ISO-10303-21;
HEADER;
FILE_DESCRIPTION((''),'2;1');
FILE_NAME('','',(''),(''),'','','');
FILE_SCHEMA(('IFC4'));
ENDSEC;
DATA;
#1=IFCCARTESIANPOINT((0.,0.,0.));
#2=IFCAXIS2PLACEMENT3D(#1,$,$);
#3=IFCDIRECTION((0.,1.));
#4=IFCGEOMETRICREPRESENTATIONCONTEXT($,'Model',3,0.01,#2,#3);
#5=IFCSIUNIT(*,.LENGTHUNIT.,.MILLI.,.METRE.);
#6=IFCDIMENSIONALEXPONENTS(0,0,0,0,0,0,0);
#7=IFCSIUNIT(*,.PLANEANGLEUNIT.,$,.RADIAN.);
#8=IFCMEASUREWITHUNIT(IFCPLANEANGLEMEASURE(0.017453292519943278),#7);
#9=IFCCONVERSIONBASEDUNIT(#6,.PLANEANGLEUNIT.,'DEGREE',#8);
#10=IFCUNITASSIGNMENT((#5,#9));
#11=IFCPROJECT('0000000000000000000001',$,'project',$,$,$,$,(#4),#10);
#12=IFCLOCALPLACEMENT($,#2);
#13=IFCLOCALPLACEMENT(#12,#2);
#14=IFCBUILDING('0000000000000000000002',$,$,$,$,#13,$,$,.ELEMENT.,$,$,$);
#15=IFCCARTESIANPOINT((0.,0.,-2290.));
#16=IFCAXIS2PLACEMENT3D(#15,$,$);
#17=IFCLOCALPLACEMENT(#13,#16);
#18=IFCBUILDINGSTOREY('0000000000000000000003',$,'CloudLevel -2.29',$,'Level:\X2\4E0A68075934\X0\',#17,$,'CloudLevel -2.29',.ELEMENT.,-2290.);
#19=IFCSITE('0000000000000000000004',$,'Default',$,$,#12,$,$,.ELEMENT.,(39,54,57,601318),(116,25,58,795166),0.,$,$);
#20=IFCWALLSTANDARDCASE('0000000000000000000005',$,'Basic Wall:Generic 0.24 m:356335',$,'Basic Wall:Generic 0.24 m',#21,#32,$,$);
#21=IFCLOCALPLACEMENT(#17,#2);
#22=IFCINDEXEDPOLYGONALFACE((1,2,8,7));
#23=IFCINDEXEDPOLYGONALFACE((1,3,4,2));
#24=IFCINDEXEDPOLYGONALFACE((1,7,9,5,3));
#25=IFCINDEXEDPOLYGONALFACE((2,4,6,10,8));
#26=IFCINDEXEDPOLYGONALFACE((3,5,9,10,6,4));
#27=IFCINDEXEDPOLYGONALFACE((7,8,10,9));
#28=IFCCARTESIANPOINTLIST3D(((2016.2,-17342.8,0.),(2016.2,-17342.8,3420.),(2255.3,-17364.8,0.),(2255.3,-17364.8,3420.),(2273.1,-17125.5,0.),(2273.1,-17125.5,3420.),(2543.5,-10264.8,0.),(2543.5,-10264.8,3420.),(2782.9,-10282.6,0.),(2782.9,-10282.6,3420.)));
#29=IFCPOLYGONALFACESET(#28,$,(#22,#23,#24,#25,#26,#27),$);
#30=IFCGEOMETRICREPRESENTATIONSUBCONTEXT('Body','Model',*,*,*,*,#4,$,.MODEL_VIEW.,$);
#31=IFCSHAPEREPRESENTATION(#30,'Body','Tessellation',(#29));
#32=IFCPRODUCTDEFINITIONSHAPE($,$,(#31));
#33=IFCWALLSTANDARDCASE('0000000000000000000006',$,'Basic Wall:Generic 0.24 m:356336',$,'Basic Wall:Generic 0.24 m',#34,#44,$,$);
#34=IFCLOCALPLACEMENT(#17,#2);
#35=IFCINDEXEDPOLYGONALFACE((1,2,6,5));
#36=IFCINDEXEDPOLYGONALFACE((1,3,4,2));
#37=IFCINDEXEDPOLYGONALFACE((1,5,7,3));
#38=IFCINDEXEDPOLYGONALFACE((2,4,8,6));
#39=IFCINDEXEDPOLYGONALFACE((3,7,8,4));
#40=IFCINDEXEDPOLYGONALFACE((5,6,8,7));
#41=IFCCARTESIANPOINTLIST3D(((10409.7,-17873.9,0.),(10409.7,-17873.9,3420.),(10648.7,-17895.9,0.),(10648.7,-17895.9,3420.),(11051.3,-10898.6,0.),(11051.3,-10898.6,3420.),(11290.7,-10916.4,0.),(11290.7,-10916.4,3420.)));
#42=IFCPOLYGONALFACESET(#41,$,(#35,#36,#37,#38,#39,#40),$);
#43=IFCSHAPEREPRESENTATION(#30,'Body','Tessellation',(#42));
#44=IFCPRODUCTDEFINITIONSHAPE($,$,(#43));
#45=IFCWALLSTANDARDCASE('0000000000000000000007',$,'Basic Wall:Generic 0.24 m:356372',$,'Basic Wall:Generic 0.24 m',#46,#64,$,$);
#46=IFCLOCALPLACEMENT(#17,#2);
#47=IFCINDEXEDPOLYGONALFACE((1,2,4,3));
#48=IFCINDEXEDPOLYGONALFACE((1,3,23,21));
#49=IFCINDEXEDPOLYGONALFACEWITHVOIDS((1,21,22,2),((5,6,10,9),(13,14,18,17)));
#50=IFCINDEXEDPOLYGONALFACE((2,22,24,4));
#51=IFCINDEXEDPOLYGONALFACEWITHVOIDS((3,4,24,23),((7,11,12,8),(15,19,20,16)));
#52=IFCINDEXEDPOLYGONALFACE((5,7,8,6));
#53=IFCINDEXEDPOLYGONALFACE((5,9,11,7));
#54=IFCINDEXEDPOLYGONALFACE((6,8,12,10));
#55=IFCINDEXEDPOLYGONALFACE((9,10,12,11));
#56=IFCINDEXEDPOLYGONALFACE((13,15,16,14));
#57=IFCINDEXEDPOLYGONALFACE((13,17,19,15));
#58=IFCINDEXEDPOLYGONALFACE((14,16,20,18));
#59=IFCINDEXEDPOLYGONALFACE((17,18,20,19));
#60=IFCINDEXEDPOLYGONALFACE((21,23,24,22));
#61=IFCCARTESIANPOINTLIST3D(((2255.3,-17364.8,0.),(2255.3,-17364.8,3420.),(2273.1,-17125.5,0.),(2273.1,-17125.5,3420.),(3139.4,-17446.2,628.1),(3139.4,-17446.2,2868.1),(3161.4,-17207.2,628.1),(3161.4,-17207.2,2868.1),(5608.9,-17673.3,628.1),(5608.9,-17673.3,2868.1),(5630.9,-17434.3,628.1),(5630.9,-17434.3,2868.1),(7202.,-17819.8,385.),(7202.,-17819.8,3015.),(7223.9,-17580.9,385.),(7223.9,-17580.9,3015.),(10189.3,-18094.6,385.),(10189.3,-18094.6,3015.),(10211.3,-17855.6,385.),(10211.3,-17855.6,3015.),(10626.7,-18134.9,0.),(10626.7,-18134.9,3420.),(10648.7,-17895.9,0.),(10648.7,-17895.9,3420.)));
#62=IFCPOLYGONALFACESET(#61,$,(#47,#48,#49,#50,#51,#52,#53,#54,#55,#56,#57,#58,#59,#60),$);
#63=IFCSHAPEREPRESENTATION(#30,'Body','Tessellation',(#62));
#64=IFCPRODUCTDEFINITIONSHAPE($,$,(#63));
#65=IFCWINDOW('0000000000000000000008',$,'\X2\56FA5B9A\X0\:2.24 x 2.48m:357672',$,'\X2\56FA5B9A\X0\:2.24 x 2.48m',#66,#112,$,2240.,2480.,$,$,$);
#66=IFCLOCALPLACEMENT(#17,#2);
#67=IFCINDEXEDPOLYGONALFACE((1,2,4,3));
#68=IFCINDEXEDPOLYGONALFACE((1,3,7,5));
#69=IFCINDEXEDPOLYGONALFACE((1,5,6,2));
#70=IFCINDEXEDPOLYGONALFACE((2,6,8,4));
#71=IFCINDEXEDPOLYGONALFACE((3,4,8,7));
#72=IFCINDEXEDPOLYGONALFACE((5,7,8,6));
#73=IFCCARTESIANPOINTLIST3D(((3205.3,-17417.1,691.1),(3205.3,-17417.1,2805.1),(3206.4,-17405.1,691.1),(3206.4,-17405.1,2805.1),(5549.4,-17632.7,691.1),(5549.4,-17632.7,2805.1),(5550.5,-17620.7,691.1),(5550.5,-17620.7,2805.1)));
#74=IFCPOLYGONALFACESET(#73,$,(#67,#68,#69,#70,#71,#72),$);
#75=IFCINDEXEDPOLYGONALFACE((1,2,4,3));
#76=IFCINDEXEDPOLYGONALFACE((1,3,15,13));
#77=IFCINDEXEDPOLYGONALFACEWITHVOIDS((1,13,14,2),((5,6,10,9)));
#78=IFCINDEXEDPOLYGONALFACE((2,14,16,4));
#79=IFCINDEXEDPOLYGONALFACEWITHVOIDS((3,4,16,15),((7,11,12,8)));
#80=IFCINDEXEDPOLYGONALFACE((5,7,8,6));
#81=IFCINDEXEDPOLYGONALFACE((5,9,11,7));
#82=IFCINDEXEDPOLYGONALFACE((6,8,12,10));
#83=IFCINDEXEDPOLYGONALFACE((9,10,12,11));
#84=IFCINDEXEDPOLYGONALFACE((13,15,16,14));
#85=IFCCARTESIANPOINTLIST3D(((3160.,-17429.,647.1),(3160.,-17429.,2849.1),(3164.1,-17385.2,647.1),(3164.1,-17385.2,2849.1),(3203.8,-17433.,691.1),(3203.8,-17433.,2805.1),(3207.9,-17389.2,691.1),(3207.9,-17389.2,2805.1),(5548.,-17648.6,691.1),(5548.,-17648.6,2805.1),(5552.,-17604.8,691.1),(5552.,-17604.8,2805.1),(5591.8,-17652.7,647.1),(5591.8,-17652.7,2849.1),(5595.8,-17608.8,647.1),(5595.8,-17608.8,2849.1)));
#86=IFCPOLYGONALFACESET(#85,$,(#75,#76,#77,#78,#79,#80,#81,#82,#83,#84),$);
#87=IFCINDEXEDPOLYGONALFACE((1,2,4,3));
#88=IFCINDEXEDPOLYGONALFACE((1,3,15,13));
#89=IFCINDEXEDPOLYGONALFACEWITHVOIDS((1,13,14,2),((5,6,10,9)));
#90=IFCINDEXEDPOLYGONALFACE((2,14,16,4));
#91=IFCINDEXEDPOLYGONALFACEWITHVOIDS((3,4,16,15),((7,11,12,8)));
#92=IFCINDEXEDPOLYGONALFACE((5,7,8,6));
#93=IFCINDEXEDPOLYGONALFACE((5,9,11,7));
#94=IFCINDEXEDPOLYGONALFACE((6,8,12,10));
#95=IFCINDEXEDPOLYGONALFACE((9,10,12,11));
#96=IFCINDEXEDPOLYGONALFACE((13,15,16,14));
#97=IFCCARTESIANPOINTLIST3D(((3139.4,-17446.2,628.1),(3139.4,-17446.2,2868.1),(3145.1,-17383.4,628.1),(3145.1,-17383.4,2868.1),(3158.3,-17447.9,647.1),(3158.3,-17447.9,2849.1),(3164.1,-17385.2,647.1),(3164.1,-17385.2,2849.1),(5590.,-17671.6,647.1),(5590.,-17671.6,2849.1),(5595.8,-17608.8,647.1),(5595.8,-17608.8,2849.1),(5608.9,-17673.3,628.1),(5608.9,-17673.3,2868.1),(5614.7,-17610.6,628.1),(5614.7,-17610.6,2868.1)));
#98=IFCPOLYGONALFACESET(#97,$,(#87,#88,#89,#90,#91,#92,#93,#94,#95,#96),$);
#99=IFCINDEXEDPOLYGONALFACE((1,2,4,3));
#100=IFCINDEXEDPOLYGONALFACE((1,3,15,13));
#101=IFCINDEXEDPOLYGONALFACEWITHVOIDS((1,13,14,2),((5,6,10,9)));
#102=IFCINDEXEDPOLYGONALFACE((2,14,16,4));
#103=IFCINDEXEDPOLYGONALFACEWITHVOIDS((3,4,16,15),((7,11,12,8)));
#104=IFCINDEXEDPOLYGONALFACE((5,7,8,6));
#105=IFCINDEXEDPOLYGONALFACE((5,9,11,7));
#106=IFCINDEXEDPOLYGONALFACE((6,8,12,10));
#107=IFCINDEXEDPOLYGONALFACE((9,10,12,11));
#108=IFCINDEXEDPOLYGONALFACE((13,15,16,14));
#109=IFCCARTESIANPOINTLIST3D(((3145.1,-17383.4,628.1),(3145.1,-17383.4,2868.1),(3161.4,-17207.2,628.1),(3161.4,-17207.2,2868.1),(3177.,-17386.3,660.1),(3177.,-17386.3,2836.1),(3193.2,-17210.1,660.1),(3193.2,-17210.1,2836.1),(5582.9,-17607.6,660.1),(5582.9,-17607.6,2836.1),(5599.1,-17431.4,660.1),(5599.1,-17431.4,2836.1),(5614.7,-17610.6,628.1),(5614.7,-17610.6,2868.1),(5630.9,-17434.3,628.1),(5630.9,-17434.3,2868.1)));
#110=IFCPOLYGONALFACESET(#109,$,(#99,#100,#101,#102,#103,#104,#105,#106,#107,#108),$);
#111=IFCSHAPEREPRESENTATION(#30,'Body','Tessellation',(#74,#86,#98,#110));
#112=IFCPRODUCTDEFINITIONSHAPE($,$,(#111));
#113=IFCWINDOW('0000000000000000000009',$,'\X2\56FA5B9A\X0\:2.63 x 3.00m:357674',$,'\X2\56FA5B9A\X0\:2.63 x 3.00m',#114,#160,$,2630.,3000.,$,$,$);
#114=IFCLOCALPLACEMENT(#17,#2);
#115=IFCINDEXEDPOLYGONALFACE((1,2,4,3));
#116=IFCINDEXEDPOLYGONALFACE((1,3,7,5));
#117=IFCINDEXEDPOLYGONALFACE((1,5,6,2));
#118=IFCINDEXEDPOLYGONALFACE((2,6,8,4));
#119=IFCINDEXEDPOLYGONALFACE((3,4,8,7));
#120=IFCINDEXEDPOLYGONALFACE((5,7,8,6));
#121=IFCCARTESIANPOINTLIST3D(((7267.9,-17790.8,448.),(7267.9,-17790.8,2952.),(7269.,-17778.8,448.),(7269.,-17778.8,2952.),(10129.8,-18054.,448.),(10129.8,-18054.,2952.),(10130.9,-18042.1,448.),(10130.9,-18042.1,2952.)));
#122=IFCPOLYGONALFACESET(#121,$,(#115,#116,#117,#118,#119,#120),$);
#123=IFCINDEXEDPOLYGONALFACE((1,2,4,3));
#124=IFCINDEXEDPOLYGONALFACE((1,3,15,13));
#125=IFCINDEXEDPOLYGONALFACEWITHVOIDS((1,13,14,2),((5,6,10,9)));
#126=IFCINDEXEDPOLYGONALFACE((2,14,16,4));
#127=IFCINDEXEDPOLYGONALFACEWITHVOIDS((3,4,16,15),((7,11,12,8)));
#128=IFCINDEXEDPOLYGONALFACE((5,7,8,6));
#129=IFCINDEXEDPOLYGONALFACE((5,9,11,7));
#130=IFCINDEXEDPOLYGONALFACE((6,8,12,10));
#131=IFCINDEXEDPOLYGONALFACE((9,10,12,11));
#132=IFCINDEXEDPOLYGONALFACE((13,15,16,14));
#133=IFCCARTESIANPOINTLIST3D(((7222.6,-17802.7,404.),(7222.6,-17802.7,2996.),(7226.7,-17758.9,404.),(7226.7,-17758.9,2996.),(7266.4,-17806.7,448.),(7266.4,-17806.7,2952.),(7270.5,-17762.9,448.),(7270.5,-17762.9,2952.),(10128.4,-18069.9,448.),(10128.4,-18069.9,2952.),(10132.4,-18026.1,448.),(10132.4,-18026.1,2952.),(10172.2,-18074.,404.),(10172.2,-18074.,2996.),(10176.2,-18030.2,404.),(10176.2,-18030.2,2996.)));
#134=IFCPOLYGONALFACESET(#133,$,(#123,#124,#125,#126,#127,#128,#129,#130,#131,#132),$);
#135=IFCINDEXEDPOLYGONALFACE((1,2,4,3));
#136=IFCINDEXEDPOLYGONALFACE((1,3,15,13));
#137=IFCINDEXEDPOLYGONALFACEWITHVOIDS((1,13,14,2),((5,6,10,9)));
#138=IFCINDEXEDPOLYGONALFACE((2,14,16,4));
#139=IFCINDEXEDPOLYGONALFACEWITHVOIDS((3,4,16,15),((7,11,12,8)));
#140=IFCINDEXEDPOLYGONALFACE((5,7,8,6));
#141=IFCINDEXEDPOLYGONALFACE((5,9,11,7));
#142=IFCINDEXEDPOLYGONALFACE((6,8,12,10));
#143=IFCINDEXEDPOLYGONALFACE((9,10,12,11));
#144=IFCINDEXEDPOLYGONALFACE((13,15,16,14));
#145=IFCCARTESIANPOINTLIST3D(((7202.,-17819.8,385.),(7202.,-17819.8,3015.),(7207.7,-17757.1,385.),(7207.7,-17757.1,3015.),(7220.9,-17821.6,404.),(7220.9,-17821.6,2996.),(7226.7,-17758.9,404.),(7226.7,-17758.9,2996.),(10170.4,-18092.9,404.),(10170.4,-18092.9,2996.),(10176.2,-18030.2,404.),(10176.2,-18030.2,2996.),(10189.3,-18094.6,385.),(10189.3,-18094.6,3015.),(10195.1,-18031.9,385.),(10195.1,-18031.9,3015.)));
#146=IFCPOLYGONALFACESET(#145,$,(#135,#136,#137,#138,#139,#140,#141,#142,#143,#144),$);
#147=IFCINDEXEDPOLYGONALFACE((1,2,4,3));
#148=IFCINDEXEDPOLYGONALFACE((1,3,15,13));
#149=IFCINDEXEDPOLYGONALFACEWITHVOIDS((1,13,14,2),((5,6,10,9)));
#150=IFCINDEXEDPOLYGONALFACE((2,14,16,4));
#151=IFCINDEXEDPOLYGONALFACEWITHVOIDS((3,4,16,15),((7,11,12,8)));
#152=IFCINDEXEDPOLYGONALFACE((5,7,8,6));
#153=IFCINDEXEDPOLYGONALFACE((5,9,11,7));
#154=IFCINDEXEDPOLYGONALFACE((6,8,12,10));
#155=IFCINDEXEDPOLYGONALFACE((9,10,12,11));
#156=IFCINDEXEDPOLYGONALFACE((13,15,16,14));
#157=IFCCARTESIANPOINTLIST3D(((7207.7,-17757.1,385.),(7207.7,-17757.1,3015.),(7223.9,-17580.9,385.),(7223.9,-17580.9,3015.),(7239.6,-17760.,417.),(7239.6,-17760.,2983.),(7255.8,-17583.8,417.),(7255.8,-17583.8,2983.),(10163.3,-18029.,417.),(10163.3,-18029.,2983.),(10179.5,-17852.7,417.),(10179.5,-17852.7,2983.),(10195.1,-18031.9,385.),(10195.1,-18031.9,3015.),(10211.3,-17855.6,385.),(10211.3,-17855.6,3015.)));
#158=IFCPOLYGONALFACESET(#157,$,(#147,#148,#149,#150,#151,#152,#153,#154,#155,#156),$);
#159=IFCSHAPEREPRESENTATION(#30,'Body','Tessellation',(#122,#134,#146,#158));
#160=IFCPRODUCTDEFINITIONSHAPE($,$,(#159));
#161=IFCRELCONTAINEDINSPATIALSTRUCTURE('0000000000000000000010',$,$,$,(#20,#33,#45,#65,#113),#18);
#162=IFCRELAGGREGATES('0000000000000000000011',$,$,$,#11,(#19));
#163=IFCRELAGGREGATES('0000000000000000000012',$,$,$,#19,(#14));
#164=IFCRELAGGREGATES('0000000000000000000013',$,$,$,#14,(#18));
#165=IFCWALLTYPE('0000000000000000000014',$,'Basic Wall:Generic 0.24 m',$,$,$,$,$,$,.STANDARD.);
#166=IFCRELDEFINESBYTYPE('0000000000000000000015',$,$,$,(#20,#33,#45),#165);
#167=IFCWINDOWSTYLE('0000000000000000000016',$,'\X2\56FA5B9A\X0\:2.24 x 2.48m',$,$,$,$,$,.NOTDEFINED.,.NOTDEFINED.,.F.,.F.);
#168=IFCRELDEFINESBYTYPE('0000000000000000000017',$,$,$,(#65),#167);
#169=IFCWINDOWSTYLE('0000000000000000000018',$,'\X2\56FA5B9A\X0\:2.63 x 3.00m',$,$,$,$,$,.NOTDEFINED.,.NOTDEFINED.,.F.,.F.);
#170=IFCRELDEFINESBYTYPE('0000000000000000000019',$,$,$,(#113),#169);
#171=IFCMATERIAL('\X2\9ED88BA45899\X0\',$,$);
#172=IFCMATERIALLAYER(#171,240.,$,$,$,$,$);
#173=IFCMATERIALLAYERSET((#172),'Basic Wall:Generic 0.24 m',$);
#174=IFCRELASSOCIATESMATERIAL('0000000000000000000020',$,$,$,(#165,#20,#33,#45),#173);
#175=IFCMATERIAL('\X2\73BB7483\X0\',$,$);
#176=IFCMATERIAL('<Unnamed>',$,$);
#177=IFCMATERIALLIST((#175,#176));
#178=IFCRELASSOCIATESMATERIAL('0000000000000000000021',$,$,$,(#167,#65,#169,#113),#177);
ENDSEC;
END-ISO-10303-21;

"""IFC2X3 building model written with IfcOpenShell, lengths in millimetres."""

from ifc_helpers import new_model, entity, si_unit, converted_unit, direction, frame, frame_2d, origin, place, context, subcontext, project, spatial, polyline, rectangle, outline, extrude, source, transform, mapped, material, material_list, layer, layer_set, layer_usage, type_object, type_shapes, element, fill, save


model = new_model("IFC2X3")

# Units and contexts
model_context = context("Model", 3, precision=0.01, world=origin(), true_north=direction((0.0, 1.0)))
body_context = subcontext(model_context, "Body", "Model", "MODEL_VIEW")
ifc_project = project(units=[si_unit("LENGTHUNIT", "METRE", prefix="MILLI"), converted_unit("PLANEANGLEUNIT", "DEGREE", entity("IfcPlaneAngleMeasure", 0.017453292519943278), si_unit("PLANEANGLEUNIT", "RADIAN"), dimensions=[0, 0, 0, 0, 0, 0, 0])], contexts=[model_context])

# Site, building, storey
site_placement = place(None, origin())
site = spatial("IfcSite", under=ifc_project, at=site_placement, Name="Default", CompositionType="ELEMENT", RefLatitude=(39, 54, 57, 601318), RefLongitude=(116, 25, 58, 795166), RefElevation=0.0)
building_placement = place(site_placement, origin())
building = spatial("IfcBuilding", under=site, at=building_placement, CompositionType="ELEMENT")
storey_placement = place(building_placement, frame((0.0, 0.0, -2290.0)))
storey = spatial("IfcBuildingStorey", under=building, at=storey_placement, Name="CloudLevel -2.29", ObjectType="Level:上标头", LongName="CloudLevel -2.29", CompositionType="ELEMENT", Elevation=-2290.0)

# Shared definitions
ifc_material_1 = material(Name="<Unnamed>")

# Walls
ifc_material_2 = material(Name="默认墙")
ifc_layer_1 = layer(ifc_material_2, 240.0)
ifc_layer_set_1 = layer_set([ifc_layer_1], Name="Basic Wall:Generic 0.24 m")
ifc_layer_usage_1 = layer_usage(ifc_layer_set_1, "AXIS2", "NEGATIVE", 120.0)
wall_type = type_object("IfcWallType", Name="Basic Wall:Generic 0.24 m", PredefinedType="STANDARD", material=ifc_layer_set_1)
wall_1_placement = place(storey_placement, frame((2663.2, -10273.7, 0.0), z_axis=(0.0, 0.0, 1.0), x_axis=(-0.074292, -0.997236, 0.0)))
element("IfcWallStandardCase", 1, at=wall_1_placement, inside=storey, type_object=wall_type, material=ifc_layer_usage_1, Name="Basic Wall:Generic 0.24 m:356335", ObjectType="Basic Wall:Generic 0.24 m", context=body_context, shape_type="SweptSolid", body=[
    extrude(outline(polyline([(7097.7, -120.0), (7101.8, 120.0), (6861.8, 120.0), (0.0, 120.0), (0.0, -120.0), (7097.7, -120.0)])), origin(), (0.0, 0.0, 1.0), 3420.0),
])
wall_2_placement = place(storey_placement, frame((10529.2, -17884.9, 0.0), z_axis=(0.0, 0.0, 1.0), x_axis=(0.091598, 0.995796, 0.0)))
element("IfcWallStandardCase", 2, at=wall_2_placement, inside=storey, type_object=wall_type, material=ifc_layer_usage_1, Name="Basic Wall:Generic 0.24 m:356336", ObjectType="Basic Wall:Generic 0.24 m", context=body_context, shape_type="SweptSolid", body=[
    extrude(outline(polyline([(7008.9, -120.0), (7004.7, 120.0), (0.0, 120.0), (0.0, -120.0), (7008.9, -120.0)])), origin(), (0.0, 0.0, 1.0), 3420.0),
])

# Wall, openings, windows
wall_3_placement = place(storey_placement, frame((2262.1, -17244.9, 0.0), z_axis=(0.0, 0.0, 1.0), x_axis=(0.995796, -0.091598, 0.0)))
wall_3 = element("IfcWallStandardCase", 3, at=wall_3_placement, inside=storey, type_object=wall_type, material=ifc_layer_usage_1, Name="Basic Wall:Generic 0.24 m:356372", ObjectType="Basic Wall:Generic 0.24 m", context=body_context, shape_type="SweptSolid", body=[
    extrude(outline(polyline([(8411.0, -120.0), (8411.0, 120.0), (8171.0, 120.0), (0.0, 120.0), (4.2, -120.0), (8411.0, -120.0)])), origin(), (0.0, 0.0, 1.0), 3420.0),
])
opening_1_placement = place(wall_3_placement, frame((3372.0, 120.0, 628.1)))
opening_1 = element("IfcOpeningElement", 4, at=opening_1_placement, cuts=wall_3, ObjectType="Opening", context=body_context, shape_type="SweptSolid", body=[
    extrude(rectangle(XDim=2240.0, YDim=2480.0, at=frame_2d((1120.0, 1240.0), x_axis=(1.0, 0.0))), frame((0.0, 0.0, 0.0), z_axis=(0.0, -1.0, 0.0), x_axis=(0.0, 0.0, 1.0)), (0.0, 0.0, 1.0), 240.0),
])
opening_2_placement = place(wall_3_placement, frame((7971.8, 120.0, 385.0)))
opening_2 = element("IfcOpeningElement", 5, at=opening_2_placement, cuts=wall_3, ObjectType="Opening", context=body_context, shape_type="SweptSolid", body=[
    extrude(rectangle(XDim=2630.0, YDim=3000.0, at=frame_2d((1315.0, 1500.0), x_axis=(1.0, 0.0))), frame((0.0, 0.0, 0.0), z_axis=(0.0, -1.0, 0.0), x_axis=(0.0, 0.0, 1.0)), (0.0, 0.0, 1.0), 240.0),
])
ifc_material_3 = material(Name="玻璃")
ifc_material_list = material_list([ifc_material_3, ifc_material_1])
window_style_1 = type_object("IfcWindowStyle", Name="固定:2.24 x 2.48m", ConstructionType="NOTDEFINED", OperationType="NOTDEFINED", ParameterTakesPrecedence=False, Sizeable=False, material=ifc_material_list)
shared_shape_1 = source(origin(), body_context, "Body", "SweptSolid", [
    extrude(rectangle(XDim=2354.0, YDim=12.0, at=frame_2d((0.0, 0.0), x_axis=(1.0, 0.0))), frame((1240.0, 225.0, 63.0), z_axis=(0.0, 0.0, 1.0), x_axis=(-1.0, 0.0, 0.0)), (0.0, 0.0, 1.0), 2114.0),
    extrude(outline(polyline([(-1221.0, -1101.0), (1221.0, -1101.0), (1221.0, 1101.0), (-1221.0, 1101.0), (-1221.0, -1101.0)]), holes=[polyline([(-1177.0, -1057.0), (-1177.0, 1057.0), (1177.0, 1057.0), (1177.0, -1057.0), (-1177.0, -1057.0)])]), frame((1240.0, 247.0, 1120.0), z_axis=(0.0, -1.0, 0.0), x_axis=(-1.0, 0.0, 0.0)), (0.0, 0.0, 1.0), 44.0),
    extrude(outline(polyline([(-1240.0, -1120.0), (1240.0, -1120.0), (1240.0, 1120.0), (-1240.0, 1120.0), (-1240.0, -1120.0)]), holes=[polyline([(-1221.0, -1101.0), (-1221.0, 1101.0), (1221.0, 1101.0), (1221.0, -1101.0), (-1221.0, -1101.0)])]), frame((1240.0, 266.0, 1120.0), z_axis=(0.0, -1.0, 0.0), x_axis=(-1.0, 0.0, 0.0)), (0.0, 0.0, 1.0), 63.0),
    extrude(outline(polyline([(-1240.0, -1120.0), (1240.0, -1120.0), (1240.0, 1120.0), (-1240.0, 1120.0), (-1240.0, -1120.0)]), holes=[polyline([(-1208.0, -1088.0), (-1208.0, 1088.0), (1208.0, 1088.0), (1208.0, -1088.0), (-1208.0, -1088.0)])]), frame((1240.0, 203.0, 1120.0), z_axis=(0.0, -1.0, 0.0), x_axis=(-1.0, 0.0, 0.0)), (0.0, 0.0, 1.0), 177.0),
])
type_shapes(window_style_1, [shared_shape_1])
window_1_placement = place(opening_1_placement, frame((0.0, 26.0, 0.0), z_axis=(0.0, 0.0, 1.0), x_axis=(-1.0, 0.0, 0.0)))
window_1 = element("IfcWindow", 6, at=window_1_placement, inside=storey, type_object=window_style_1, material=ifc_material_list, Name="固定:2.24 x 2.48m:357672", ObjectType="固定:2.24 x 2.48m", OverallHeight=2240.0, OverallWidth=2480.0, context=body_context, shape_type="MappedRepresentation", body=[
    mapped(shared_shape_1, transform((0.0, 0.0, 0.0), scale=1.0)),
])
fill(opening_1, window_1)
window_style_2 = type_object("IfcWindowStyle", Name="固定:2.63 x 3.00m", ConstructionType="NOTDEFINED", OperationType="NOTDEFINED", ParameterTakesPrecedence=False, Sizeable=False, material=ifc_material_list)
shared_shape_2 = source(origin(), body_context, "Body", "SweptSolid", [
    extrude(rectangle(XDim=2874.0, YDim=12.0, at=frame_2d((0.0, 0.0), x_axis=(1.0, 0.0))), frame((1500.0, 225.0, 63.0), z_axis=(0.0, 0.0, 1.0), x_axis=(-1.0, 0.0, 0.0)), (0.0, 0.0, 1.0), 2504.0),
    extrude(outline(polyline([(-1481.0, -1296.0), (1481.0, -1296.0), (1481.0, 1296.0), (-1481.0, 1296.0), (-1481.0, -1296.0)]), holes=[polyline([(-1437.0, -1252.0), (-1437.0, 1252.0), (1437.0, 1252.0), (1437.0, -1252.0), (-1437.0, -1252.0)])]), frame((1500.0, 247.0, 1315.0), z_axis=(0.0, -1.0, 0.0), x_axis=(-1.0, 0.0, 0.0)), (0.0, 0.0, 1.0), 44.0),
    extrude(outline(polyline([(-1500.0, -1315.0), (1500.0, -1315.0), (1500.0, 1315.0), (-1500.0, 1315.0), (-1500.0, -1315.0)]), holes=[polyline([(-1481.0, -1296.0), (-1481.0, 1296.0), (1481.0, 1296.0), (1481.0, -1296.0), (-1481.0, -1296.0)])]), frame((1500.0, 266.0, 1315.0), z_axis=(0.0, -1.0, 0.0), x_axis=(-1.0, 0.0, 0.0)), (0.0, 0.0, 1.0), 63.0),
    extrude(outline(polyline([(-1500.0, -1315.0), (1500.0, -1315.0), (1500.0, 1315.0), (-1500.0, 1315.0), (-1500.0, -1315.0)]), holes=[polyline([(-1468.0, -1283.0), (-1468.0, 1283.0), (1468.0, 1283.0), (1468.0, -1283.0), (-1468.0, -1283.0)])]), frame((1500.0, 203.0, 1315.0), z_axis=(0.0, -1.0, 0.0), x_axis=(-1.0, 0.0, 0.0)), (0.0, 0.0, 1.0), 177.0),
])
type_shapes(window_style_2, [shared_shape_2])
window_2_placement = place(opening_2_placement, frame((0.0, 26.0, 0.0), z_axis=(0.0, 0.0, 1.0), x_axis=(-1.0, 0.0, 0.0)))
window_2 = element("IfcWindow", 7, at=window_2_placement, inside=storey, type_object=window_style_2, material=ifc_material_list, Name="固定:2.63 x 3.00m:357674", ObjectType="固定:2.63 x 3.00m", OverallHeight=2630.0, OverallWidth=3000.0, context=body_context, shape_type="MappedRepresentation", body=[
    mapped(shared_shape_2, transform((0.0, 0.0, 0.0), scale=1.0)),
])
fill(opening_2, window_2)

save(model, "model.ifc")
